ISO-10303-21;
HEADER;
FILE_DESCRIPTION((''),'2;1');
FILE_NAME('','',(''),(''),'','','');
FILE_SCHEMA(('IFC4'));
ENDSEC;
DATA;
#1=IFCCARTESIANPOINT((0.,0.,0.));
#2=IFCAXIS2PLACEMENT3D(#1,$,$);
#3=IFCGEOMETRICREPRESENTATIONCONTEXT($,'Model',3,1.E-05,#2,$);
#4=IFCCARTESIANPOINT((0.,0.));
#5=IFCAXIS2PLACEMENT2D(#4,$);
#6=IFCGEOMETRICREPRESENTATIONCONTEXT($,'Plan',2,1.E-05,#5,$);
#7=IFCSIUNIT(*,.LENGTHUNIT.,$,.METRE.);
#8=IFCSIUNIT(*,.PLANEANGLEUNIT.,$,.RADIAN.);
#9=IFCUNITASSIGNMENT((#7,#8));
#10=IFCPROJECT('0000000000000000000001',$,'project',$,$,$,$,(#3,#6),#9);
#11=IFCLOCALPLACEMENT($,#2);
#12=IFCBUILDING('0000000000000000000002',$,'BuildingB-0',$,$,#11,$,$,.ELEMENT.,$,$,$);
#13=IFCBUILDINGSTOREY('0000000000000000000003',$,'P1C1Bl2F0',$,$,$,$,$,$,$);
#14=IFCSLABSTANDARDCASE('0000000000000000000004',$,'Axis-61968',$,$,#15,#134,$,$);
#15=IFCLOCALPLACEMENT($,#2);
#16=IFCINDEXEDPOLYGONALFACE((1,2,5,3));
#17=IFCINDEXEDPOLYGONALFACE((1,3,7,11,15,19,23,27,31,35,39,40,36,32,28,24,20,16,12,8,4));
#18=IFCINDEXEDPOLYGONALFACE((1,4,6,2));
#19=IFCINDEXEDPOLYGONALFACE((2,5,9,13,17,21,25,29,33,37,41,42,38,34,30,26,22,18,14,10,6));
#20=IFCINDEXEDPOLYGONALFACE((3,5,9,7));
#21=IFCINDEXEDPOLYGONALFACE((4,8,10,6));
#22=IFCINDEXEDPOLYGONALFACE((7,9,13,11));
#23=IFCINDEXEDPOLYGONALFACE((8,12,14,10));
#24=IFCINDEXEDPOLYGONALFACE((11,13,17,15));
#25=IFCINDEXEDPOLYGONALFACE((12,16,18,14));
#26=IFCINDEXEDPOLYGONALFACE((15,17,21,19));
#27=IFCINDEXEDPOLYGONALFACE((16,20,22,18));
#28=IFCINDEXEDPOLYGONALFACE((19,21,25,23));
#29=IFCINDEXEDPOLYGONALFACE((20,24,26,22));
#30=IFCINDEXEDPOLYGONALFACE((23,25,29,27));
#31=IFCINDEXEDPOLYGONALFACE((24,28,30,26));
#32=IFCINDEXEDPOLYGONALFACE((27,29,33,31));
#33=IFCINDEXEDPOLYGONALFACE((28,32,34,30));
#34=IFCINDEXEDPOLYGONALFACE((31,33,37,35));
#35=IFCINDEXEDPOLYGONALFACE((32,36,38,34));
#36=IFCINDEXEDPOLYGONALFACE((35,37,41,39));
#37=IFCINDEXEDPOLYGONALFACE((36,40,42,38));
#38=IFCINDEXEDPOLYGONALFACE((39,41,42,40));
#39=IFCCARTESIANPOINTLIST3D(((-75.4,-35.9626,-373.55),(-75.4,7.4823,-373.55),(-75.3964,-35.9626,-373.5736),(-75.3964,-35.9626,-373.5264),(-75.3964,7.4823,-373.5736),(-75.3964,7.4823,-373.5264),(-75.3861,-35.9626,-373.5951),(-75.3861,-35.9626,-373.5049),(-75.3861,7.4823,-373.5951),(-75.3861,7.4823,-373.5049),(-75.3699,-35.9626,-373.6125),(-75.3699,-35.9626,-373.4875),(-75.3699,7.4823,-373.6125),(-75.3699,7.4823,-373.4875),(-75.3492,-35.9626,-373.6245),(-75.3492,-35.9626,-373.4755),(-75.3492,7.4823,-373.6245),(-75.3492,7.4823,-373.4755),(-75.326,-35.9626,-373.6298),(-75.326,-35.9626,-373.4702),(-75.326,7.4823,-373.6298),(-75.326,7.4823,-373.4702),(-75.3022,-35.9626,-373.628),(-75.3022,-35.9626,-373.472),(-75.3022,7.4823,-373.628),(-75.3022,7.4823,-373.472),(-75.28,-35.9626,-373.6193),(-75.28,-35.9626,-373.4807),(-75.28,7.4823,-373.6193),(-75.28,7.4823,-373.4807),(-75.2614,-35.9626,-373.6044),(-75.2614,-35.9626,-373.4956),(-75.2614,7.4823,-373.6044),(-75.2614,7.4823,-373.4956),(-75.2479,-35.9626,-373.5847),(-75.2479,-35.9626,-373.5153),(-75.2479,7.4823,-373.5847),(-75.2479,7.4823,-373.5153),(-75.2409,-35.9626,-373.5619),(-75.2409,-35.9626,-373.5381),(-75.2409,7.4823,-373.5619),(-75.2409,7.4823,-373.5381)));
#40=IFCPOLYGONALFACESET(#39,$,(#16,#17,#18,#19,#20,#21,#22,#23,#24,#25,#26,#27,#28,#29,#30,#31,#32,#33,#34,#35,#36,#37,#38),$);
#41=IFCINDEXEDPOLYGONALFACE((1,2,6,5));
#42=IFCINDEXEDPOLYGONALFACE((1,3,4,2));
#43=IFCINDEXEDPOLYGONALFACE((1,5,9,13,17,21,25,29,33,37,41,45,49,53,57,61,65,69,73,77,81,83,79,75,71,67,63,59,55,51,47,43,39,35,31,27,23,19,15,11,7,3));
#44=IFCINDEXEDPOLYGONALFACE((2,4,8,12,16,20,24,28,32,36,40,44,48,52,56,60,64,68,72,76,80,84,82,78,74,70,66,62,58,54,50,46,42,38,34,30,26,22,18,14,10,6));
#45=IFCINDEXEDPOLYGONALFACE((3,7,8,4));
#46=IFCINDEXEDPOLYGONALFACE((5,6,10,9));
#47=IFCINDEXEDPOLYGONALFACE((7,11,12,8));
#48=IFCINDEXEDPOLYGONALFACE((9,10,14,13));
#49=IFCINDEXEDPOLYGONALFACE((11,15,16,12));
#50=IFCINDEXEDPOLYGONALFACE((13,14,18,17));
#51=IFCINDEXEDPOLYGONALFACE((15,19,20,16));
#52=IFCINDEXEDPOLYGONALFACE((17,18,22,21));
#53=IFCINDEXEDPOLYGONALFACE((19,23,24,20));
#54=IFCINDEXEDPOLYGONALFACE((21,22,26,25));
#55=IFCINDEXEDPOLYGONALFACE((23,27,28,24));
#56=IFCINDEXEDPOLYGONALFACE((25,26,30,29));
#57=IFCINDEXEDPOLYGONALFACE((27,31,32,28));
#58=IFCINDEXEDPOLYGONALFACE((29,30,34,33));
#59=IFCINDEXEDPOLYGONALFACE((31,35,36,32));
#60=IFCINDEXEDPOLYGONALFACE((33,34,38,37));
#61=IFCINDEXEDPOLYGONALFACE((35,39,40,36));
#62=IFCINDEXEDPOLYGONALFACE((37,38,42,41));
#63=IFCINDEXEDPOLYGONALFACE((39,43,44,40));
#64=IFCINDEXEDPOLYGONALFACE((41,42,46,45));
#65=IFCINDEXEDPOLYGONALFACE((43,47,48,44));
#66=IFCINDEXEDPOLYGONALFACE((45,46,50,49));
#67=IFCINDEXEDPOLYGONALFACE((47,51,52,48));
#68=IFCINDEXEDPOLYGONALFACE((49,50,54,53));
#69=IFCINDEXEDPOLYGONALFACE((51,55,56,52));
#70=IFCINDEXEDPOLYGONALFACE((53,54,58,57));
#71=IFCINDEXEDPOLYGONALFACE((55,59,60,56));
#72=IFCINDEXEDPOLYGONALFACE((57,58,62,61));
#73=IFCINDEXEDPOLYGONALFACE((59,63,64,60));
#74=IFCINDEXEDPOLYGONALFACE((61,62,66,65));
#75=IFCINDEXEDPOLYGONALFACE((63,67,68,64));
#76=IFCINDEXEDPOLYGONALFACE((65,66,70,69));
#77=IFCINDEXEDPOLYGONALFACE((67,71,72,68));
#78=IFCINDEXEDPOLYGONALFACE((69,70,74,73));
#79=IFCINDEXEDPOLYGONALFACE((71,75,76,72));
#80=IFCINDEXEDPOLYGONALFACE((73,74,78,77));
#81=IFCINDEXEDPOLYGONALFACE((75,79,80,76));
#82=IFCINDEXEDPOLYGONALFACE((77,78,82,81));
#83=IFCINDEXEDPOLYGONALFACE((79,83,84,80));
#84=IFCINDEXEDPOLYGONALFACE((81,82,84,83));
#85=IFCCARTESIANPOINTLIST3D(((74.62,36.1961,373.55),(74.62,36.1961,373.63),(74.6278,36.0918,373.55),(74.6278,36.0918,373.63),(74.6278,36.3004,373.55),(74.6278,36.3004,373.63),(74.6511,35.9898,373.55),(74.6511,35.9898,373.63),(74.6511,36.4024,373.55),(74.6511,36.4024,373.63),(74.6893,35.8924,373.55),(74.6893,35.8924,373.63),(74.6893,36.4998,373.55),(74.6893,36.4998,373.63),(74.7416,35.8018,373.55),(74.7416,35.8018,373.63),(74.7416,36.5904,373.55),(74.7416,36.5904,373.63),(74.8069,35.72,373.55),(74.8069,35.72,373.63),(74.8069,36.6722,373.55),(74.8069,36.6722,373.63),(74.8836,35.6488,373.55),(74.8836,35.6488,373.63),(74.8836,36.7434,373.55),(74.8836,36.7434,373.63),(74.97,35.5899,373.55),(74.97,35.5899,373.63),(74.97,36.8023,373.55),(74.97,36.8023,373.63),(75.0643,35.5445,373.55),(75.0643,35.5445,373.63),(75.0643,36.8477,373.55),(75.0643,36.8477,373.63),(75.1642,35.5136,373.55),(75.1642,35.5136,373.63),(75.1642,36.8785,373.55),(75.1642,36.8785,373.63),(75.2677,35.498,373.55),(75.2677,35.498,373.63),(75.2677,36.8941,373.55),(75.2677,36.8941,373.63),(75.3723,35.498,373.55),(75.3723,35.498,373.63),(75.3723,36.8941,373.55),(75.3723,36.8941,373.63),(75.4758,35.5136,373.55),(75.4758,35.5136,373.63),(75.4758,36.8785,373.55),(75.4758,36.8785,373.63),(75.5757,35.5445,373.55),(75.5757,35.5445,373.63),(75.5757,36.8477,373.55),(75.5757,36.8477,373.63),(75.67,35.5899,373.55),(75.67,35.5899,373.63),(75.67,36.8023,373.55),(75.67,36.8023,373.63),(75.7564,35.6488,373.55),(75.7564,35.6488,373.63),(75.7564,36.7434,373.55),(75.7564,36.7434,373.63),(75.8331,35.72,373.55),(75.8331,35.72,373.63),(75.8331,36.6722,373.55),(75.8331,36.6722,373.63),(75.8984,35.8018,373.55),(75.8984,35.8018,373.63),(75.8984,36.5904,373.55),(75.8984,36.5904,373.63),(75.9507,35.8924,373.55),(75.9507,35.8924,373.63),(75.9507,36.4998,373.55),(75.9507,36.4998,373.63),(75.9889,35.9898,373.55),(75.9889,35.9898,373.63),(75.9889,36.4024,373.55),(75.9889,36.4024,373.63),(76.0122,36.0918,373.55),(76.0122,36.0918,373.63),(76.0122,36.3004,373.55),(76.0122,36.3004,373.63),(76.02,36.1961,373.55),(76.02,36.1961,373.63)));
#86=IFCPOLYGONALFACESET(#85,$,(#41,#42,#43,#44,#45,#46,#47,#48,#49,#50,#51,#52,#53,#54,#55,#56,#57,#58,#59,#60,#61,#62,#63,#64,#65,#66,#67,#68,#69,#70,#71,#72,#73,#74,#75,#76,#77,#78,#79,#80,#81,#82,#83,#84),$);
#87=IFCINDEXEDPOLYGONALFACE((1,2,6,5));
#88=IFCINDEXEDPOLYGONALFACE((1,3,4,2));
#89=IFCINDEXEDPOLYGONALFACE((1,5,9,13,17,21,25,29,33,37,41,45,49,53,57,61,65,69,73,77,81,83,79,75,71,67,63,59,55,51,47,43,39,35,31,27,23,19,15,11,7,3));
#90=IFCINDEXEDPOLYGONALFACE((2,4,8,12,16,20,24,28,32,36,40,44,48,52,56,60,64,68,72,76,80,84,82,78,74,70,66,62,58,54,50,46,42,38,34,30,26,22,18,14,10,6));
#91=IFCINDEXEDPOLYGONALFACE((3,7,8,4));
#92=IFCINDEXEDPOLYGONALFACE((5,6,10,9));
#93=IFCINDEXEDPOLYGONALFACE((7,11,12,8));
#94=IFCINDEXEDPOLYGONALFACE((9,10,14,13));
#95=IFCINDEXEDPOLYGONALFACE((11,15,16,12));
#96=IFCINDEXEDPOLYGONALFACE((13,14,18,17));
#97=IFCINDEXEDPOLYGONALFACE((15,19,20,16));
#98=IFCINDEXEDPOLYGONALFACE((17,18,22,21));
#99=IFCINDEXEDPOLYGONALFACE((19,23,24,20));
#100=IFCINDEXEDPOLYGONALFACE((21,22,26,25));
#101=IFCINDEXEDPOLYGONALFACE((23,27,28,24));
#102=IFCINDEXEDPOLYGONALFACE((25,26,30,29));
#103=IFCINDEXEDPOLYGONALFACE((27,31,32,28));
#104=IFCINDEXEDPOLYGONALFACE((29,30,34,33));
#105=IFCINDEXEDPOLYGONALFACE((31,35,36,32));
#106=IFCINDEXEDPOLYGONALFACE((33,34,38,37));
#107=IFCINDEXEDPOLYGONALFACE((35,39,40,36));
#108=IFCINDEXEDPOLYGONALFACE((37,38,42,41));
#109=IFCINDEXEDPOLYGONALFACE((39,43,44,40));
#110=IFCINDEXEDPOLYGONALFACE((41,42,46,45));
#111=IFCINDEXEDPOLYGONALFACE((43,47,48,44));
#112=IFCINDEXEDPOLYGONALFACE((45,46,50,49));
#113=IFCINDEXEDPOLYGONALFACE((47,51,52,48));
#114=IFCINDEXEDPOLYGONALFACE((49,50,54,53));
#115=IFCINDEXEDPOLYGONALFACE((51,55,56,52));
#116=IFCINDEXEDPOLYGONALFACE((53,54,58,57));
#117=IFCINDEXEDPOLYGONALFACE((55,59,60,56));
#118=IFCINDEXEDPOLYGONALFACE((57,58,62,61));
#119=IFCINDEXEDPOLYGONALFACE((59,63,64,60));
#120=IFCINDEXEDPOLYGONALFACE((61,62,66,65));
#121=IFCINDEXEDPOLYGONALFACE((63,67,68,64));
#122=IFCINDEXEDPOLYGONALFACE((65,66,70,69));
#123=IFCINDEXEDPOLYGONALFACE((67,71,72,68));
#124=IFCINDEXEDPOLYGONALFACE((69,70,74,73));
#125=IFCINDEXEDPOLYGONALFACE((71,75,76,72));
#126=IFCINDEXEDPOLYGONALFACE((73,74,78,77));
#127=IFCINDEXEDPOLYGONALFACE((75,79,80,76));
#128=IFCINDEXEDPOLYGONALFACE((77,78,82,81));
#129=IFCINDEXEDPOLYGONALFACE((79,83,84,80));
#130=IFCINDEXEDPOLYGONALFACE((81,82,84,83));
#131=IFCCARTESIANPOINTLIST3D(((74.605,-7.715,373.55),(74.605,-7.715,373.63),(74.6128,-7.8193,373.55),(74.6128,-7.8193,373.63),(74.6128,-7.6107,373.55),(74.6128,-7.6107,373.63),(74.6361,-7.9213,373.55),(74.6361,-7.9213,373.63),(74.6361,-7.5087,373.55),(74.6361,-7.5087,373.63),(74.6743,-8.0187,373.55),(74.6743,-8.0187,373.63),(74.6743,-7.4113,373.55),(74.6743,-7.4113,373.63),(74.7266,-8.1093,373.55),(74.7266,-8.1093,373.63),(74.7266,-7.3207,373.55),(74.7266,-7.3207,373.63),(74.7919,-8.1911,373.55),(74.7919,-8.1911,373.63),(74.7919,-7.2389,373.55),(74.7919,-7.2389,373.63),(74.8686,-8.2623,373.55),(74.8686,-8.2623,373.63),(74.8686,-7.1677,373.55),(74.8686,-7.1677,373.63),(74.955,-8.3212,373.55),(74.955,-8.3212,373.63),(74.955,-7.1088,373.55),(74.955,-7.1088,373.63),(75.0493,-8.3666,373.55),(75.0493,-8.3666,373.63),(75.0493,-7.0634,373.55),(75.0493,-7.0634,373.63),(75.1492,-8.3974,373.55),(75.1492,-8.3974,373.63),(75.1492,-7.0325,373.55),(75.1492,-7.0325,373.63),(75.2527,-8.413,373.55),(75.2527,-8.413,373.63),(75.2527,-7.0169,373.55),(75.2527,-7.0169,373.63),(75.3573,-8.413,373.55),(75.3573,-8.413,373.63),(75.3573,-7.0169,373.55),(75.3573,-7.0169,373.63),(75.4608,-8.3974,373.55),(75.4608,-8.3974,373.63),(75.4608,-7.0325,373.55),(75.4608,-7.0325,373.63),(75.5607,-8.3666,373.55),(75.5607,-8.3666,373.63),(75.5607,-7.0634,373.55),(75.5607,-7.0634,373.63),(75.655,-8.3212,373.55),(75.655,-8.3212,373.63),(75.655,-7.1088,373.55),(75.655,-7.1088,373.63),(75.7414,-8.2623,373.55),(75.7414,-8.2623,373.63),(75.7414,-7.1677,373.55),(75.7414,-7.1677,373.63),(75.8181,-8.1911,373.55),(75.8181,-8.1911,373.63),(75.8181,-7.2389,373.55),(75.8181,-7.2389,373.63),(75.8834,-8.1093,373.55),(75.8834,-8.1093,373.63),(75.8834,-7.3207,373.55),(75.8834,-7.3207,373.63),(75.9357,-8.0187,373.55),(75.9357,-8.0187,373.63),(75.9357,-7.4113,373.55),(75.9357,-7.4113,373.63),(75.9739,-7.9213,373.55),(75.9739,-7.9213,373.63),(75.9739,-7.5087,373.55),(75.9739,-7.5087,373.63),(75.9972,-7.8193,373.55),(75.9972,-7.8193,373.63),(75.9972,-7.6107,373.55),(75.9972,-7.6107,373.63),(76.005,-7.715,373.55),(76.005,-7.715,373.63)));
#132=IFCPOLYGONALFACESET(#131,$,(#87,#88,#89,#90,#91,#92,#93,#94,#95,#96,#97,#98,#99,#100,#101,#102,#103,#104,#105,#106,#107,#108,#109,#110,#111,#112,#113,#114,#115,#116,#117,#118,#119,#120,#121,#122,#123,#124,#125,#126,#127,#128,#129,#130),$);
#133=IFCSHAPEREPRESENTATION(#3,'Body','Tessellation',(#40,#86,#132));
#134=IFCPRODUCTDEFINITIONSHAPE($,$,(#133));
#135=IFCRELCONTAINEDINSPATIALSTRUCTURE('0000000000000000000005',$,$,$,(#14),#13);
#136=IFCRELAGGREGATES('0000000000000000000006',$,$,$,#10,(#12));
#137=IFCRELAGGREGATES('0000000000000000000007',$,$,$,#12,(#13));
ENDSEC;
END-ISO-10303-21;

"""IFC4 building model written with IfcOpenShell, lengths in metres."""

from ifc_helpers import new_model, entity, si_unit, frame, origin, origin_2d, place, context, project, spatial, circle, extrude, element, save


model = new_model("IFC4")

# Units and contexts
model_context = context("Model", 3, precision=1e-05, world=origin())
plan_context = context("Plan", 2, precision=1e-05, world=origin_2d())
ifc_project = project(units=[si_unit("LENGTHUNIT", "METRE"), si_unit("PLANEANGLEUNIT", "RADIAN")], contexts=[model_context, plan_context])

# Building, storey
building_placement = place(None, origin())
building = spatial("IfcBuilding", under=ifc_project, at=building_placement, Name="BuildingB-0", CompositionType="ELEMENT")
storey = spatial("IfcBuildingStorey", under=building, Name="P1C1Bl2F0")

# Slab
element("IfcSlabStandardCase", 1, inside=storey, Name="Axis-61968", context=model_context, shape_type="AdvancedSweptSolid", body=[
    entity("IfcSurfaceCurveSweptAreaSolid", entity("IfcCircleProfileDef", "AREA", None, None, 0.08), None, entity("IfcPolyline", [entity("IfcCartesianPoint", [75.32, 35.9626, 373.55]), entity("IfcCartesianPoint", [75.32, -7.4823, 373.55])]), None, None, entity("IfcPlane", entity("IfcAxis2Placement3D", entity("IfcCartesianPoint", [75.32, 35.9626, 373.55]), entity("IfcDirection", [0.0, 0.0, 1.0]), entity("IfcDirection", [1.0, 0.0, 0.0])))),
    extrude(circle(Radius=0.7), frame((75.32, 36.1961, 373.55)), (0.0, 0.0, 1.0), 0.08),
    extrude(circle(Radius=0.7), frame((75.305, -7.715, 373.55)), (0.0, 0.0, 1.0), 0.08),
])

save(model, "model.ifc")
